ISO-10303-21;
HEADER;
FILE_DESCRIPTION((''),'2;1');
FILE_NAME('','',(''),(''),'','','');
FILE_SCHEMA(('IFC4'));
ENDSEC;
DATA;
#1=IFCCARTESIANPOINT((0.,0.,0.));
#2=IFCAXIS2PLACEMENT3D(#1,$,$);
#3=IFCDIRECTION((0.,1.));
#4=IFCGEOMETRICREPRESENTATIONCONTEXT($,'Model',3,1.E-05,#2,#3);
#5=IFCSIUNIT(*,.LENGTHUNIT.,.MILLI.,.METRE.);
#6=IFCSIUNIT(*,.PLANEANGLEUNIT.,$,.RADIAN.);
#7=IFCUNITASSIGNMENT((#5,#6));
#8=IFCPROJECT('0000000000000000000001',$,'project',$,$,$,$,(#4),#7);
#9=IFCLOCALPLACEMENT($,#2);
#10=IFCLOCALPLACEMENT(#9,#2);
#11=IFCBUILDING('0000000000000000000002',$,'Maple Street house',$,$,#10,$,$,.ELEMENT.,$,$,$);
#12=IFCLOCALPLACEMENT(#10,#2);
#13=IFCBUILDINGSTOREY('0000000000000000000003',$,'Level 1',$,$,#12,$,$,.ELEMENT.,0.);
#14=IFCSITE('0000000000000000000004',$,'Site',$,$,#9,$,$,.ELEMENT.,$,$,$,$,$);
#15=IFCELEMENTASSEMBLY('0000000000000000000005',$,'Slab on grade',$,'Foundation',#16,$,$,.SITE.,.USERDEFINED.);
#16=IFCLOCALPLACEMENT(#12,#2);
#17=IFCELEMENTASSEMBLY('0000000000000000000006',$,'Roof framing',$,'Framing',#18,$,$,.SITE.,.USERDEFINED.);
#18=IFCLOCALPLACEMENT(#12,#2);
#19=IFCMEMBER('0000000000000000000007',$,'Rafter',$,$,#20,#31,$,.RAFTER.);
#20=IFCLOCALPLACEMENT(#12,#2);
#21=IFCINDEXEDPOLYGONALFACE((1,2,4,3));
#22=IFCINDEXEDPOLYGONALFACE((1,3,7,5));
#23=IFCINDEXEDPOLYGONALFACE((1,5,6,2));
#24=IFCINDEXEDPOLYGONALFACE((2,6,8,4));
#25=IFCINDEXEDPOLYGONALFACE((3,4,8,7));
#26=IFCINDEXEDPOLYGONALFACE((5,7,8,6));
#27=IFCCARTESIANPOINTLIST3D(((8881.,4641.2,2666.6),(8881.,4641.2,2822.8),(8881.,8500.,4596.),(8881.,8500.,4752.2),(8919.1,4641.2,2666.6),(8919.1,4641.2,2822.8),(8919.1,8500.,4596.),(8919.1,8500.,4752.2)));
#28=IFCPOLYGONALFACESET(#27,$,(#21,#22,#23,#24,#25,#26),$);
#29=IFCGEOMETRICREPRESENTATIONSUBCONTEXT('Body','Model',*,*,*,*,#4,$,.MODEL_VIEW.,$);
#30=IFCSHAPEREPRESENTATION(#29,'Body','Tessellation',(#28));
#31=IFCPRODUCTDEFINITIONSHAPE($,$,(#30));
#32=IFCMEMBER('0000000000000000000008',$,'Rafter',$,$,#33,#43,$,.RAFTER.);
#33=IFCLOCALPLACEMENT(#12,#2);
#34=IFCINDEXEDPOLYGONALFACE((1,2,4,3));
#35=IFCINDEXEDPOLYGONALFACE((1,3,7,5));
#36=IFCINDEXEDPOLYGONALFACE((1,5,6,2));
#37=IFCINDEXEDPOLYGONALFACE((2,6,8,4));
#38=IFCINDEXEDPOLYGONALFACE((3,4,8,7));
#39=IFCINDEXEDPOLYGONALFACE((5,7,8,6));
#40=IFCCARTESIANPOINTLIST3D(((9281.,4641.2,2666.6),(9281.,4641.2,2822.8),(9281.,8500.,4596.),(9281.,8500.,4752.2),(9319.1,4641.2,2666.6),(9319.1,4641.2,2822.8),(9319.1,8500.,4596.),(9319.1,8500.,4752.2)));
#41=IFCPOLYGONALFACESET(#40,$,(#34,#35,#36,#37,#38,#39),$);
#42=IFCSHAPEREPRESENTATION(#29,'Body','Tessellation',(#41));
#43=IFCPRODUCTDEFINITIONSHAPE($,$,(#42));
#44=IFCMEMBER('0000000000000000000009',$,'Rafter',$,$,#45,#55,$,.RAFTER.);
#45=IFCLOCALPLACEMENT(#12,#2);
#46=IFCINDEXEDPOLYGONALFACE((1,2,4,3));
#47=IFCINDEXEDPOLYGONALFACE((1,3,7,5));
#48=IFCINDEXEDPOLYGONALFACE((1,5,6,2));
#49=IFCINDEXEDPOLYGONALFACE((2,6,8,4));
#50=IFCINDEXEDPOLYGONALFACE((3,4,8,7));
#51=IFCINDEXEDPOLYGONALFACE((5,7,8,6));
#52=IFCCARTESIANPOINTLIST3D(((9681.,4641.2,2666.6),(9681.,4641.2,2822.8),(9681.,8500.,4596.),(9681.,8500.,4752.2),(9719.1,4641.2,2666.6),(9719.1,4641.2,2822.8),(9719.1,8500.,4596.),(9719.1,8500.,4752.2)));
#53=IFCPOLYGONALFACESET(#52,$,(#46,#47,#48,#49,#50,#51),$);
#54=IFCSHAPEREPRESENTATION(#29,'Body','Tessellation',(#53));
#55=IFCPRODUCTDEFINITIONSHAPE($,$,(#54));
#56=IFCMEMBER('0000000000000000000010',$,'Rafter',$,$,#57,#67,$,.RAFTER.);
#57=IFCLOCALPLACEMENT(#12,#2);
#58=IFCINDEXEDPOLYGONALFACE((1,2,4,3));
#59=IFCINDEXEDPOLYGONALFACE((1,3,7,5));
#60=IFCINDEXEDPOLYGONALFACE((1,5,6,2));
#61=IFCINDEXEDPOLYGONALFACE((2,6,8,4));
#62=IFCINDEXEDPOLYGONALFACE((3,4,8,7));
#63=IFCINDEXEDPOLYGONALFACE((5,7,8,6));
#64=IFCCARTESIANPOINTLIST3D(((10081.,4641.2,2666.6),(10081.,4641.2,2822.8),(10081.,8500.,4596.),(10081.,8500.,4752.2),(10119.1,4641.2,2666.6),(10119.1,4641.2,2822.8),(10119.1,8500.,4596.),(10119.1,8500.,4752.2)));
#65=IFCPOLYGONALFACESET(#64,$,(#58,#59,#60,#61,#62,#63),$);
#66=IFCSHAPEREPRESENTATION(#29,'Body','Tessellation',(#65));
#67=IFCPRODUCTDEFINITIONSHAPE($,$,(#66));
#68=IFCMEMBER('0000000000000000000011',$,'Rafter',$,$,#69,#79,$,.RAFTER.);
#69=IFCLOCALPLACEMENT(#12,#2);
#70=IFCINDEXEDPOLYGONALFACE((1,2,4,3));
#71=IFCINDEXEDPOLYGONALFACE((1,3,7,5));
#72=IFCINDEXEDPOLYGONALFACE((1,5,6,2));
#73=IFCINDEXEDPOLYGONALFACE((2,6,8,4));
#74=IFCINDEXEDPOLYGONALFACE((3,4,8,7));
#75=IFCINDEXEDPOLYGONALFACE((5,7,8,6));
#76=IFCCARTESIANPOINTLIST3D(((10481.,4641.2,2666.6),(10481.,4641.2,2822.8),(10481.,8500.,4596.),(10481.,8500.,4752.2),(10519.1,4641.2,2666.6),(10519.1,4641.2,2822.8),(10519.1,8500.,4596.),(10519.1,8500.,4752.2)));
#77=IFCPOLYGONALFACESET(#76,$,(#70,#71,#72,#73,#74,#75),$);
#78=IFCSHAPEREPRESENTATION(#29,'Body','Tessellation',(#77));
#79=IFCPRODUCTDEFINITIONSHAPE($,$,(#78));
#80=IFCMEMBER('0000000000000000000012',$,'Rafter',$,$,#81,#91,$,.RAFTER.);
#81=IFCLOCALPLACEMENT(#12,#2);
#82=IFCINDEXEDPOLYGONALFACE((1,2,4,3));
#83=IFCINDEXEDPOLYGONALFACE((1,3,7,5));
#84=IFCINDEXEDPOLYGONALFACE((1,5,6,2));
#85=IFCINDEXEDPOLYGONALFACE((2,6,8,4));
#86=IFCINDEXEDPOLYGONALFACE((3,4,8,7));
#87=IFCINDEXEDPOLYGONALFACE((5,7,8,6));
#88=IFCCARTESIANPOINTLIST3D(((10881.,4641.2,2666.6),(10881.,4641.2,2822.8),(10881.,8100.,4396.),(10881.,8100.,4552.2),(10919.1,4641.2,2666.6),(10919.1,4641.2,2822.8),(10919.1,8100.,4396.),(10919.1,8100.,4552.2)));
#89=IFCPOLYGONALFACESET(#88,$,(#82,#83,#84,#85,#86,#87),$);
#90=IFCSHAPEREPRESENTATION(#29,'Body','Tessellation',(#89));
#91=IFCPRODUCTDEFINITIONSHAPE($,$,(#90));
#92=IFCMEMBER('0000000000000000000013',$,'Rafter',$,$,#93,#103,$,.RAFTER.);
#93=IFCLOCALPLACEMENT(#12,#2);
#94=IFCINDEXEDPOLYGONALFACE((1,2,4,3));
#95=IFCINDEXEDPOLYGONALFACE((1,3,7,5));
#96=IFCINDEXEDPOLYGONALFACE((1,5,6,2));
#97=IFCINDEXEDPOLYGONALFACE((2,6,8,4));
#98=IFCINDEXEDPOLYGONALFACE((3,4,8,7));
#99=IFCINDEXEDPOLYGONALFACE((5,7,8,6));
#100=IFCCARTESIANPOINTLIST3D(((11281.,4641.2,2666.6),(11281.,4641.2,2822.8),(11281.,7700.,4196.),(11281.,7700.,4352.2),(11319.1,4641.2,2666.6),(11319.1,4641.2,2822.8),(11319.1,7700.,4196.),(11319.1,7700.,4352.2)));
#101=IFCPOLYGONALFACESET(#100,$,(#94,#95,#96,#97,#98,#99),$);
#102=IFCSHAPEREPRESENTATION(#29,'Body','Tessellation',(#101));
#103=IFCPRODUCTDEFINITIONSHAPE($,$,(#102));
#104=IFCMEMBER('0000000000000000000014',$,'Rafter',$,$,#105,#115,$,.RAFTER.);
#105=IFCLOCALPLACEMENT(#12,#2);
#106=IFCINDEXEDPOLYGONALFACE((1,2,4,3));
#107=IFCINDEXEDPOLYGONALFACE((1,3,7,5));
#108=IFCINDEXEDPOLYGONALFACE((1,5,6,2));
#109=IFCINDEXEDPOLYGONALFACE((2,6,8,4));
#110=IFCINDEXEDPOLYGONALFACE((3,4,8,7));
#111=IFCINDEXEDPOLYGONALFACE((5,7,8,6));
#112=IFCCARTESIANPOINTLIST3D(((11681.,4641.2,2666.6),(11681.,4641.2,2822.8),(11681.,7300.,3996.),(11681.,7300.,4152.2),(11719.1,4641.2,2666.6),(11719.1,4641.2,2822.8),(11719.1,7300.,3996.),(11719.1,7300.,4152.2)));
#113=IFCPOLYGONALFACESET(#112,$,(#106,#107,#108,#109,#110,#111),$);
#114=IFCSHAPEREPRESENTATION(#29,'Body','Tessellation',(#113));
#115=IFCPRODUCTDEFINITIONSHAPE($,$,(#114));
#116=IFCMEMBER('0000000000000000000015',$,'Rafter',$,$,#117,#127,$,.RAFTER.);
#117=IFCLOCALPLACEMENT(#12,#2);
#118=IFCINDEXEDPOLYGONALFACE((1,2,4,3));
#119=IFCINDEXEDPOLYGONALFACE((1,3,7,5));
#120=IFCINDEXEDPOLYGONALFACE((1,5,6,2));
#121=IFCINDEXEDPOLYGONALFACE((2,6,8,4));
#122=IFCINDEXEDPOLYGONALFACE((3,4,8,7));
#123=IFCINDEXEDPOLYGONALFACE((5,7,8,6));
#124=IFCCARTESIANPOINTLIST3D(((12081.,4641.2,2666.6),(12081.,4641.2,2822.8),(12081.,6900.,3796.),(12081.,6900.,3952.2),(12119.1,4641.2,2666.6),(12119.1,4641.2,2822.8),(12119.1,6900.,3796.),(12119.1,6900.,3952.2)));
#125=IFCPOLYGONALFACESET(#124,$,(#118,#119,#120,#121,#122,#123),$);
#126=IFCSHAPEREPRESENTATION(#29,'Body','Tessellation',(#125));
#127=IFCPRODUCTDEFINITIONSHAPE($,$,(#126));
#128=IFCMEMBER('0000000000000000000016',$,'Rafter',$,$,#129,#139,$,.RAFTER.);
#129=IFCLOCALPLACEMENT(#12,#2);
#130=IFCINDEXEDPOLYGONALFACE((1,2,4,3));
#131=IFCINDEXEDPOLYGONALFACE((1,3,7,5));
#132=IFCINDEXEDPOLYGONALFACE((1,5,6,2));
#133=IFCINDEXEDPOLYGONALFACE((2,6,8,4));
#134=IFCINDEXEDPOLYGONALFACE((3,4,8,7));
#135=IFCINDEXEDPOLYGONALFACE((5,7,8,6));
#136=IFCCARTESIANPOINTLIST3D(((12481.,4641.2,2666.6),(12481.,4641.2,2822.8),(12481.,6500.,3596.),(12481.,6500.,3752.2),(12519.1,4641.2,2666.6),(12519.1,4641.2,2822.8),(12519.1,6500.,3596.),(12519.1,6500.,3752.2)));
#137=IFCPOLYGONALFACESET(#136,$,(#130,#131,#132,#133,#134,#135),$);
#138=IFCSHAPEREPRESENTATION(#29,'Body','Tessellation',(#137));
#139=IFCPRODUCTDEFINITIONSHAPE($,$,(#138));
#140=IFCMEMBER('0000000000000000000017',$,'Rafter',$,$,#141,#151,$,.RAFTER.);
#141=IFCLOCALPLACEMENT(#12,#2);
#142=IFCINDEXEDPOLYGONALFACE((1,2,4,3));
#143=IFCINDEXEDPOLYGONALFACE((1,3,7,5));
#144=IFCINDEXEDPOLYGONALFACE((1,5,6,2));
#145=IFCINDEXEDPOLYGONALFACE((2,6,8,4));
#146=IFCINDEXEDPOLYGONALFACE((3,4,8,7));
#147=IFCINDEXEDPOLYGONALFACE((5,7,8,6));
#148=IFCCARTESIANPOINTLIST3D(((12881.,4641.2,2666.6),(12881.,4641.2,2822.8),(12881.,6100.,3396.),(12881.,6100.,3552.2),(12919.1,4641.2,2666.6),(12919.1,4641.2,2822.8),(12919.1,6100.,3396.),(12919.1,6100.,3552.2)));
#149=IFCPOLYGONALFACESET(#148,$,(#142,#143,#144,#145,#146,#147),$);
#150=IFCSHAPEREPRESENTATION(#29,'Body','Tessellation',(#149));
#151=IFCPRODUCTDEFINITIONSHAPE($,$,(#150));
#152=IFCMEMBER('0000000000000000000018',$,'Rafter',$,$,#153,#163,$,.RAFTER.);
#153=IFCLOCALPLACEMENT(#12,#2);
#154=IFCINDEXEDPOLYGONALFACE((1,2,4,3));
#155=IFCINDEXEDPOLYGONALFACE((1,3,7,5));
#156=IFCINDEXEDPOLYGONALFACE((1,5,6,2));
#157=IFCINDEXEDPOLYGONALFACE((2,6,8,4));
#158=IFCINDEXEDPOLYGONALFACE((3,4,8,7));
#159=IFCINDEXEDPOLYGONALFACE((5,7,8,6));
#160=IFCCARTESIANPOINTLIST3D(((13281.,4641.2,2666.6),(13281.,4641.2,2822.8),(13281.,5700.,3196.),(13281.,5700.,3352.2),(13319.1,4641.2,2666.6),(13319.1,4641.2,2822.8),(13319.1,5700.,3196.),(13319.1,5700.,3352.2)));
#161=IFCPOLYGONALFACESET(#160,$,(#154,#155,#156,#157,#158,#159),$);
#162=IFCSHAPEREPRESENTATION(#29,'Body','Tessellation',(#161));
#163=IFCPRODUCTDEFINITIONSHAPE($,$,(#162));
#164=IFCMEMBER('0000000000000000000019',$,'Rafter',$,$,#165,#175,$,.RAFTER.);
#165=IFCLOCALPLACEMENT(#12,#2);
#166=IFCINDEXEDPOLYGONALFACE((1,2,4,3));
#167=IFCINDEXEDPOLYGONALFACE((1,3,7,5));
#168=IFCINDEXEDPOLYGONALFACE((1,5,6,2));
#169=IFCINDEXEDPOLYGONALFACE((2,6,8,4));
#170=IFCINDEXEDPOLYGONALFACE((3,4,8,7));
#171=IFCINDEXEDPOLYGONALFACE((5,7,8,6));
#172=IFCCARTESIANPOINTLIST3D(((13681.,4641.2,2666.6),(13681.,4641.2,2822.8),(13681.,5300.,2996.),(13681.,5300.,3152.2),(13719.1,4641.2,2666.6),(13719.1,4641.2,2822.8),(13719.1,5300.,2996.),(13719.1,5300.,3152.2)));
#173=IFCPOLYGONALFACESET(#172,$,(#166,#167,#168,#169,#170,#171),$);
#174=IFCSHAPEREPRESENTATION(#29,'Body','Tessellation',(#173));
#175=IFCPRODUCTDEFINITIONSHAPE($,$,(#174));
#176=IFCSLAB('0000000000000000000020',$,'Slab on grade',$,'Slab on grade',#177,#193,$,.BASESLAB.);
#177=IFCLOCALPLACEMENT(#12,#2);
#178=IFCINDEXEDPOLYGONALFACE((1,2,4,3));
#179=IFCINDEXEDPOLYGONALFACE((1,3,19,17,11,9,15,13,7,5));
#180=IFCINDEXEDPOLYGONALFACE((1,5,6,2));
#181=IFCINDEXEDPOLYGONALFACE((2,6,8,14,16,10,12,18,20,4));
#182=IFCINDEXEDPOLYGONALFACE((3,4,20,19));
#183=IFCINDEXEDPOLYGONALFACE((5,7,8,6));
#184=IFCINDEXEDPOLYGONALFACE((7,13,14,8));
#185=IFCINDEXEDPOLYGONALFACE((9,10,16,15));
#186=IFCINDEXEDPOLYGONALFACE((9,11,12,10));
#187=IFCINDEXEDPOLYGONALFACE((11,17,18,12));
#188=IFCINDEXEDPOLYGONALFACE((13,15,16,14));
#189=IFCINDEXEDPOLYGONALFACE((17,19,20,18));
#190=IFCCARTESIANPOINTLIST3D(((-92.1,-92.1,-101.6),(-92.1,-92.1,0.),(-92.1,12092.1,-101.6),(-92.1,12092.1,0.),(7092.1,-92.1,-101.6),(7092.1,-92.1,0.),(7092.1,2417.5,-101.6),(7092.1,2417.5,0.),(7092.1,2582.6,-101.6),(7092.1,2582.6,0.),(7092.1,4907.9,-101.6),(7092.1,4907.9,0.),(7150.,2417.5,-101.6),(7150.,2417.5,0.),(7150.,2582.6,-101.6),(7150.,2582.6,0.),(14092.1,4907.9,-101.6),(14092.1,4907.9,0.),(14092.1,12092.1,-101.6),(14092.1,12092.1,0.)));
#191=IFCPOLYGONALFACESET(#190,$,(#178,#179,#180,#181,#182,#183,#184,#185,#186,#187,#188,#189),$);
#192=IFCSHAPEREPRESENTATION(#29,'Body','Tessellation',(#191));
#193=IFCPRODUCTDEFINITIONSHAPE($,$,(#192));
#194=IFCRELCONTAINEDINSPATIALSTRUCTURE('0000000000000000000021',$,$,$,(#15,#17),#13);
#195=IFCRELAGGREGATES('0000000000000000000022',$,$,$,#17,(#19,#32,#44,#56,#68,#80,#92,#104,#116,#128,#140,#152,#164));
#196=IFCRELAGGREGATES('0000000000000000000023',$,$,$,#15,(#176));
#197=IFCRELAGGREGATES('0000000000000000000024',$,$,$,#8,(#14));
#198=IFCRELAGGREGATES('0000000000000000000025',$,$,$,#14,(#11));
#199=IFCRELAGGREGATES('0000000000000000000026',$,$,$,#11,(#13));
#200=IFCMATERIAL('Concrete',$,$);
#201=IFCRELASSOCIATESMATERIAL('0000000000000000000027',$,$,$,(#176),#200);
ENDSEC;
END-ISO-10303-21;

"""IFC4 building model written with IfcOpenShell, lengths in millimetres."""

from ifc_helpers import new_model, si_unit, direction, frame, origin, origin_with_axes, place, context, subcontext, project, spatial, polyline, outline, extrude, material, element, aggregate, save


model = new_model("IFC4")

# Units and contexts
model_context = context("Model", 3, precision=1e-05, world=origin(), true_north=direction((0.0, 1.0)))
body_context = subcontext(model_context, "Body", "Model", "MODEL_VIEW")
ifc_project = project(units=[si_unit("LENGTHUNIT", "METRE", prefix="MILLI"), si_unit("PLANEANGLEUNIT", "RADIAN")], contexts=[model_context])

# Site, building, storey
site_placement = place(None, origin())
site = spatial("IfcSite", under=ifc_project, at=site_placement, Name="Site", CompositionType="ELEMENT")
building_placement = place(site_placement, origin())
building = spatial("IfcBuilding", under=site, at=building_placement, Name="Maple Street house", CompositionType="ELEMENT")
storey_placement = place(building_placement, origin())
storey = spatial("IfcBuildingStorey", under=building, at=storey_placement, Name="Level 1", CompositionType="ELEMENT", Elevation=0.0)

# Element assembly
assembly_1_placement = place(storey_placement, origin_with_axes())
assembly_1 = element("IfcElementAssembly", 1, at=assembly_1_placement, inside=storey, Name="Slab on grade", ObjectType="Foundation", AssemblyPlace="SITE", PredefinedType="USERDEFINED")
ifc_material = material(Name="Concrete")

# Element assembly, members
assembly_2_placement = place(storey_placement, origin_with_axes())
assembly_2 = element("IfcElementAssembly", 2, at=assembly_2_placement, inside=storey, Name="Roof framing", ObjectType="Framing", AssemblyPlace="SITE", PredefinedType="USERDEFINED")
member_1_placement = place(storey_placement, origin_with_axes())
member_1 = element("IfcMember", 3, at=member_1_placement, Name="Rafter", PredefinedType="RAFTER", context=body_context, shape_type="SweptSolid", body=[
    extrude(outline(polyline([(0.0, 0.0), (38.1, 0.0), (38.1, 156.2), (0.0, 156.2), (0.0, 0.0)])), frame((8919.1, 4641.2, 2666.7), z_axis=(0.0, 1.0, 0.0), x_axis=(-1.0, 0.0, 0.0)), (0.0, 0.447214, 0.894427), 4314.2),
])
member_2_placement = place(storey_placement, origin_with_axes())
member_2 = element("IfcMember", 4, at=member_2_placement, Name="Rafter", PredefinedType="RAFTER", context=body_context, shape_type="SweptSolid", body=[
    extrude(outline(polyline([(0.0, 0.0), (38.1, 0.0), (38.1, 156.2), (0.0, 156.2), (0.0, 0.0)])), frame((9319.1, 4641.2, 2666.7), z_axis=(0.0, 1.0, 0.0), x_axis=(-1.0, 0.0, 0.0)), (0.0, 0.447214, 0.894427), 4314.2),
])
member_3_placement = place(storey_placement, origin_with_axes())
member_3 = element("IfcMember", 5, at=member_3_placement, Name="Rafter", PredefinedType="RAFTER", context=body_context, shape_type="SweptSolid", body=[
    extrude(outline(polyline([(0.0, 0.0), (38.1, 0.0), (38.1, 156.2), (0.0, 156.2), (0.0, 0.0)])), frame((9719.1, 4641.2, 2666.7), z_axis=(0.0, 1.0, 0.0), x_axis=(-1.0, 0.0, 0.0)), (0.0, 0.447214, 0.894427), 4314.2),
])
member_4_placement = place(storey_placement, origin_with_axes())
member_4 = element("IfcMember", 6, at=member_4_placement, Name="Rafter", PredefinedType="RAFTER", context=body_context, shape_type="SweptSolid", body=[
    extrude(outline(polyline([(0.0, 0.0), (38.1, 0.0), (38.1, 156.2), (0.0, 156.2), (0.0, 0.0)])), frame((10119.1, 4641.2, 2666.7), z_axis=(0.0, 1.0, 0.0), x_axis=(-1.0, 0.0, 0.0)), (0.0, 0.447214, 0.894427), 4314.2),
])
member_5_placement = place(storey_placement, origin_with_axes())
member_5 = element("IfcMember", 7, at=member_5_placement, Name="Rafter", PredefinedType="RAFTER", context=body_context, shape_type="SweptSolid", body=[
    extrude(outline(polyline([(0.0, 0.0), (38.1, 0.0), (38.1, 156.2), (0.0, 156.2), (0.0, 0.0)])), frame((10519.1, 4641.2, 2666.7), z_axis=(0.0, 1.0, 0.0), x_axis=(-1.0, 0.0, 0.0)), (0.0, 0.447214, 0.894427), 4314.2),
])
member_6_placement = place(storey_placement, origin_with_axes())
member_6 = element("IfcMember", 8, at=member_6_placement, Name="Rafter", PredefinedType="RAFTER", context=body_context, shape_type="SweptSolid", body=[
    extrude(outline(polyline([(0.0, 0.0), (38.1, 0.0), (38.1, 156.2), (0.0, 156.2), (0.0, 0.0)])), frame((10919.1, 4641.2, 2666.7), z_axis=(0.0, 1.0, 0.0), x_axis=(-1.0, 0.0, 0.0)), (0.0, 0.447214, 0.894427), 3867.0),
])
member_7_placement = place(storey_placement, origin_with_axes())
member_7 = element("IfcMember", 9, at=member_7_placement, Name="Rafter", PredefinedType="RAFTER", context=body_context, shape_type="SweptSolid", body=[
    extrude(outline(polyline([(0.0, 0.0), (38.1, 0.0), (38.1, 156.2), (0.0, 156.2), (0.0, 0.0)])), frame((11319.1, 4641.2, 2666.7), z_axis=(0.0, 1.0, 0.0), x_axis=(-1.0, 0.0, 0.0)), (0.0, 0.447214, 0.894427), 3419.8),
])
member_8_placement = place(storey_placement, origin_with_axes())
member_8 = element("IfcMember", 10, at=member_8_placement, Name="Rafter", PredefinedType="RAFTER", context=body_context, shape_type="SweptSolid", body=[
    extrude(outline(polyline([(0.0, 0.0), (38.1, 0.0), (38.1, 156.2), (0.0, 156.2), (0.0, 0.0)])), frame((11719.1, 4641.2, 2666.7), z_axis=(0.0, 1.0, 0.0), x_axis=(-1.0, 0.0, 0.0)), (0.0, 0.447214, 0.894427), 2972.6),
])
member_9_placement = place(storey_placement, origin_with_axes())
member_9 = element("IfcMember", 11, at=member_9_placement, Name="Rafter", PredefinedType="RAFTER", context=body_context, shape_type="SweptSolid", body=[
    extrude(outline(polyline([(0.0, 0.0), (38.1, 0.0), (38.1, 156.2), (0.0, 156.2), (0.0, 0.0)])), frame((12119.1, 4641.2, 2666.7), z_axis=(0.0, 1.0, 0.0), x_axis=(-1.0, 0.0, 0.0)), (0.0, 0.447214, 0.894427), 2525.4),
])
member_10_placement = place(storey_placement, origin_with_axes())
member_10 = element("IfcMember", 12, at=member_10_placement, Name="Rafter", PredefinedType="RAFTER", context=body_context, shape_type="SweptSolid", body=[
    extrude(outline(polyline([(0.0, 0.0), (38.1, 0.0), (38.1, 156.2), (0.0, 156.2), (0.0, 0.0)])), frame((12519.1, 4641.2, 2666.7), z_axis=(0.0, 1.0, 0.0), x_axis=(-1.0, 0.0, 0.0)), (0.0, 0.447214, 0.894427), 2078.2),
])
member_11_placement = place(storey_placement, origin_with_axes())
member_11 = element("IfcMember", 13, at=member_11_placement, Name="Rafter", PredefinedType="RAFTER", context=body_context, shape_type="SweptSolid", body=[
    extrude(outline(polyline([(0.0, 0.0), (38.1, 0.0), (38.1, 156.2), (0.0, 156.2), (0.0, 0.0)])), frame((12919.1, 4641.2, 2666.7), z_axis=(0.0, 1.0, 0.0), x_axis=(-1.0, 0.0, 0.0)), (0.0, 0.447214, 0.894427), 1631.0),
])
member_12_placement = place(storey_placement, origin_with_axes())
member_12 = element("IfcMember", 14, at=member_12_placement, Name="Rafter", PredefinedType="RAFTER", context=body_context, shape_type="SweptSolid", body=[
    extrude(outline(polyline([(0.0, 0.0), (38.1, 0.0), (38.1, 156.2), (0.0, 156.2), (0.0, 0.0)])), frame((13319.1, 4641.2, 2666.7), z_axis=(0.0, 1.0, 0.0), x_axis=(-1.0, 0.0, 0.0)), (0.0, 0.447214, 0.894427), 1183.7),
])
member_13_placement = place(storey_placement, origin_with_axes())
member_13 = element("IfcMember", 15, at=member_13_placement, Name="Rafter", PredefinedType="RAFTER", context=body_context, shape_type="SweptSolid", body=[
    extrude(outline(polyline([(0.0, 0.0), (38.1, 0.0), (38.1, 156.2), (0.0, 156.2), (0.0, 0.0)])), frame((13719.1, 4641.2, 2666.7), z_axis=(0.0, 1.0, 0.0), x_axis=(-1.0, 0.0, 0.0)), (0.0, 0.447214, 0.894427), 736.5),
])
aggregate(assembly_2, [member_1, member_2, member_3, member_4, member_5, member_6, member_7, member_8, member_9, member_10, member_11, member_12, member_13])

# Slab
slab_placement = place(storey_placement, origin_with_axes())
slab = element("IfcSlab", 16, at=slab_placement, material=ifc_material, Name="Slab on grade", ObjectType="Slab on grade", PredefinedType="BASESLAB", context=body_context, shape_type="SweptSolid", body=[
    extrude(outline(polyline([(7092.1, 2417.5), (7150.0, 2417.5), (7150.0, 2582.6), (7092.1, 2582.6), (7092.1, 4907.9), (14092.1, 4907.9), (14092.1, 12092.1), (-92.1, 12092.1), (-92.1, -92.1), (7092.1, -92.1), (7092.1, 2417.5)])), frame((0.0, 0.0, -101.6)), (0.0, 0.0, 1.0), 101.6),
])
aggregate(assembly_1, [slab])

save(model, "model.ifc")
